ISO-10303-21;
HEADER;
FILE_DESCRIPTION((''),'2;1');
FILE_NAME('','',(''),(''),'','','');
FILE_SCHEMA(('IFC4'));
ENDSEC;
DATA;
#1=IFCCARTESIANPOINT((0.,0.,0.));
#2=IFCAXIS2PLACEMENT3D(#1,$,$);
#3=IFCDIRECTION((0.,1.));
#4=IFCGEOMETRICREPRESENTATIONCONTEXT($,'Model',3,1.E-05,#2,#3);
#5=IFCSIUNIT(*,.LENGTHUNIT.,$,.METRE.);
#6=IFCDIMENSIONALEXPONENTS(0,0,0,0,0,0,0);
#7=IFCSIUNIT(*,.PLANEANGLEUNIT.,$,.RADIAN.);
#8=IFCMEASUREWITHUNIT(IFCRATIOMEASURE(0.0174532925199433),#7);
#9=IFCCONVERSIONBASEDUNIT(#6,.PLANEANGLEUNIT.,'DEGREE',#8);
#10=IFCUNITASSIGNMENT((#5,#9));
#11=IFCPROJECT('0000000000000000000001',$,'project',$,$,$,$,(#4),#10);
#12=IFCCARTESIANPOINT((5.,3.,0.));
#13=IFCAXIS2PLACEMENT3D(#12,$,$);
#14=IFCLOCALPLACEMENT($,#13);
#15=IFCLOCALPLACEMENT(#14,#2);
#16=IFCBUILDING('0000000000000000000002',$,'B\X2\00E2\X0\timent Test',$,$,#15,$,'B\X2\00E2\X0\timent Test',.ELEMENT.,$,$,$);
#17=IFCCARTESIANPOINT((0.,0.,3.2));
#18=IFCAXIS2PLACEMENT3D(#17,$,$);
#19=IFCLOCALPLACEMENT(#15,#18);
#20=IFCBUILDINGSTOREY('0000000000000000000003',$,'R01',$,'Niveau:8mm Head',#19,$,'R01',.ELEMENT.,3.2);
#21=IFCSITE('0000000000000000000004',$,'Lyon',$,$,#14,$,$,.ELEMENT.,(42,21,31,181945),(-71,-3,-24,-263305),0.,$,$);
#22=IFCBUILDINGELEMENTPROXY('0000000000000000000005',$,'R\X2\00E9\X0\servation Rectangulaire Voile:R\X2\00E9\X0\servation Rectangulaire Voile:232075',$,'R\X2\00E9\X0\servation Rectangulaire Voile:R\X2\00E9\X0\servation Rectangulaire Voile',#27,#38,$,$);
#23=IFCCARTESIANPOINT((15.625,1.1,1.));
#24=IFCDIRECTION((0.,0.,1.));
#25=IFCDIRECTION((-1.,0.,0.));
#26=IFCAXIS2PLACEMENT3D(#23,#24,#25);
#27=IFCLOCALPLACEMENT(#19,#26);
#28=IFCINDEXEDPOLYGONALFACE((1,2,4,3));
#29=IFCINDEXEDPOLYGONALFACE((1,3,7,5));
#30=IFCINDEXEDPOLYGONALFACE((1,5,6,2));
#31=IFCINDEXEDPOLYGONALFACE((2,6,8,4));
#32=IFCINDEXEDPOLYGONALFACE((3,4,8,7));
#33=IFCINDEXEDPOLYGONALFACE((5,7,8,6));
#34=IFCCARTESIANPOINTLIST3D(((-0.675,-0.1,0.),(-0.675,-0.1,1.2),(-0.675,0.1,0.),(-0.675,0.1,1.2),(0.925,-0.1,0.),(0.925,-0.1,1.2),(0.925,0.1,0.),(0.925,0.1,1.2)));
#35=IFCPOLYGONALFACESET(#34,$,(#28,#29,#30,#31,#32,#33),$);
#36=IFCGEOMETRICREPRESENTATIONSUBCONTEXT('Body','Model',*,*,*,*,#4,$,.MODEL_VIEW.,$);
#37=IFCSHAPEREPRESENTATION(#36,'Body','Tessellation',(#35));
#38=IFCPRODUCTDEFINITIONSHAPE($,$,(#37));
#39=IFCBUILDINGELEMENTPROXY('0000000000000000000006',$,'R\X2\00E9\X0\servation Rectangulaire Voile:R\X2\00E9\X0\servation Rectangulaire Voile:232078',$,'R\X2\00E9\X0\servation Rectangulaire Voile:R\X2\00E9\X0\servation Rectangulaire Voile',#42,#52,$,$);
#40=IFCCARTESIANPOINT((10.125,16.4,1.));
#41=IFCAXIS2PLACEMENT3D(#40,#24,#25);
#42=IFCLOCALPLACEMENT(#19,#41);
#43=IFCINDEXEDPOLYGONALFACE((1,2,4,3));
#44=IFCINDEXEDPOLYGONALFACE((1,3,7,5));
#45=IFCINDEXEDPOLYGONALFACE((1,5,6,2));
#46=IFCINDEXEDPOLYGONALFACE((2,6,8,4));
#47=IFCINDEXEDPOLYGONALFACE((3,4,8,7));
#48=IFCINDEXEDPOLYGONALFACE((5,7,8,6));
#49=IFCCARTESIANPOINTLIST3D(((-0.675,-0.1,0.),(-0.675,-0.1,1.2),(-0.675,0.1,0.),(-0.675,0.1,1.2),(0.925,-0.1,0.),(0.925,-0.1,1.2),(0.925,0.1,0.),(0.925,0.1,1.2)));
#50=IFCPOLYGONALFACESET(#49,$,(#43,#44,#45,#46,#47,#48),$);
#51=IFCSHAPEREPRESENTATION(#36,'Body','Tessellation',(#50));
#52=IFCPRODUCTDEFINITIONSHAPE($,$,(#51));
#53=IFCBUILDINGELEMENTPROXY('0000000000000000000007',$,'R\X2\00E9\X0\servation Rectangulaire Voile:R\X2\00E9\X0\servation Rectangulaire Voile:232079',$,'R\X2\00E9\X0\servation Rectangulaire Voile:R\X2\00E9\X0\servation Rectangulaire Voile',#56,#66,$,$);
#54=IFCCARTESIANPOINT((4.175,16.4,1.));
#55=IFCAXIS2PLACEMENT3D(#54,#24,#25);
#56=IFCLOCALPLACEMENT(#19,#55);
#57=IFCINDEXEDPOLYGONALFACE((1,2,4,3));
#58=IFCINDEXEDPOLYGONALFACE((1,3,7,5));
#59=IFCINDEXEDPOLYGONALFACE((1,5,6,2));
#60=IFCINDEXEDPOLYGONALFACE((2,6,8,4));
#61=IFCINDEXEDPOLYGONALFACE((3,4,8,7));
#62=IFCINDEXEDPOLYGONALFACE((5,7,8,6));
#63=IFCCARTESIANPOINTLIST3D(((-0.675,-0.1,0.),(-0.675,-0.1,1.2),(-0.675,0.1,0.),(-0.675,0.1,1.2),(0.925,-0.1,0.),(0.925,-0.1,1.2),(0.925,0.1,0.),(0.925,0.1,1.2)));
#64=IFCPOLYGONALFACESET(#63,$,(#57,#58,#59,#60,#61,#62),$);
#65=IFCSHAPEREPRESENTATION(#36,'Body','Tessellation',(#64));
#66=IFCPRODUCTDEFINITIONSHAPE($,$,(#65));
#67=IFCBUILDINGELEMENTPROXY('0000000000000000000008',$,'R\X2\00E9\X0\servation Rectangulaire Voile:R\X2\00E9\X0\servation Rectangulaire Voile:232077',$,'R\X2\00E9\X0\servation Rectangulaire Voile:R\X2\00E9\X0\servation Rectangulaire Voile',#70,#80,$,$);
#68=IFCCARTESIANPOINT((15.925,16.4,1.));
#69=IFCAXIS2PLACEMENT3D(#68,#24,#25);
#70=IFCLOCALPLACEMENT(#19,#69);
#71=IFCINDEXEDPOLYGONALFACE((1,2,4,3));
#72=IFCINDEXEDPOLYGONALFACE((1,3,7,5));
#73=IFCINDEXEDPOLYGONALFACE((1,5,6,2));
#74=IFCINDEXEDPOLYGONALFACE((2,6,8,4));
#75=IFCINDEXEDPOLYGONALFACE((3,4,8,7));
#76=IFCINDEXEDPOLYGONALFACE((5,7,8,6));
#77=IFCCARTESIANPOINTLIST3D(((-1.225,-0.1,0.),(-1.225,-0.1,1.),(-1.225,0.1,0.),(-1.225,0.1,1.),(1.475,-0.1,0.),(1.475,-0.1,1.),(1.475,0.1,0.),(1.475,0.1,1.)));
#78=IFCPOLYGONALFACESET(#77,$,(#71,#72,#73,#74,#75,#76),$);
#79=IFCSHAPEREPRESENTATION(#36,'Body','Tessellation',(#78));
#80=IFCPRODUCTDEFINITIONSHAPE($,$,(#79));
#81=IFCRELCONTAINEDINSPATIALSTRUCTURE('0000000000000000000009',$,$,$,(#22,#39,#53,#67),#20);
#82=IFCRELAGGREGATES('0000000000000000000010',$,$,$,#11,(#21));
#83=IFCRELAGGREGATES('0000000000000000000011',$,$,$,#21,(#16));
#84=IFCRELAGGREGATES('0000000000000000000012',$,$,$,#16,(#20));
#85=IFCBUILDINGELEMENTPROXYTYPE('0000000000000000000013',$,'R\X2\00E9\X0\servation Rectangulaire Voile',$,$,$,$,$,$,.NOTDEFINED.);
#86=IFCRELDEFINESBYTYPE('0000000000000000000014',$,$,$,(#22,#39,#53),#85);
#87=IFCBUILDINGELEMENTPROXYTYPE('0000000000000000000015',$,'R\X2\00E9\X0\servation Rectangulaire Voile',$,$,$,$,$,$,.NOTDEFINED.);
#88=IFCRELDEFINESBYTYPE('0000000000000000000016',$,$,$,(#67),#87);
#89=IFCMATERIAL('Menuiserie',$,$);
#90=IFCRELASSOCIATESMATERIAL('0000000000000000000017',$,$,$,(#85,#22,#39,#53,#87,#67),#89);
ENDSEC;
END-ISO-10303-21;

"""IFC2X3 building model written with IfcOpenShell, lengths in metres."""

from ifc_helpers import new_model, entity, si_unit, converted_unit, direction, frame, origin, origin_2d_with_axis, place, context, subcontext, project, spatial, rectangle, extrude, source, transform, mapped, material, type_object, type_shapes, element, save


model = new_model("IFC2X3")

# Units and contexts
model_context = context("Model", 3, precision=1e-05, world=origin(), true_north=direction((0.0, 1.0)))
body_context = subcontext(model_context, "Body", "Model", "MODEL_VIEW")
ifc_project = project(units=[si_unit("LENGTHUNIT", "METRE"), converted_unit("PLANEANGLEUNIT", "DEGREE", entity("IfcRatioMeasure", 0.0174532925199433), si_unit("PLANEANGLEUNIT", "RADIAN"), dimensions=[0, 0, 0, 0, 0, 0, 0])], contexts=[model_context])

# Site, building, storey
site_placement = place(None, frame((5.0, 3.0, 0.0)))
site = spatial("IfcSite", under=ifc_project, at=site_placement, Name="Lyon", CompositionType="ELEMENT", RefLatitude=(42, 21, 31, 181945), RefLongitude=(-71, -3, -24, -263305), RefElevation=0.0)
building_placement = place(site_placement, origin())
building = spatial("IfcBuilding", under=site, at=building_placement, Name="Bâtiment Test", LongName="Bâtiment Test", CompositionType="ELEMENT")
storey_placement = place(building_placement, frame((0.0, 0.0, 3.2)))
storey = spatial("IfcBuildingStorey", under=building, at=storey_placement, Name="R01", ObjectType="Niveau:8mm Head", LongName="R01", CompositionType="ELEMENT", Elevation=3.2)

# Building element proxies
ifc_material_1 = material(Name="Menuiserie")
building_element_proxy_type_1 = type_object("IfcBuildingElementProxyType", Name="Réservation Rectangulaire Voile", PredefinedType="NOTDEFINED", material=ifc_material_1)
shared_shape_1 = source(origin(), body_context, "Body", "SweptSolid", [
    extrude(rectangle(XDim=0.2, YDim=1.6, at=origin_2d_with_axis()), frame((0.125, 0.0, 0.0), z_axis=(0.0, 0.0, 1.0), x_axis=(0.0, 1.0, 0.0)), (0.0, 0.0, 1.0), 1.2),
])
type_shapes(building_element_proxy_type_1, [shared_shape_1])
for number, where, z_axis, x_axis, name in (
    (1, (15.625, 1.1, 1.0), (0.0, 0.0, 1.0), (-1.0, 0.0, 0.0), "Réservation Rectangulaire Voile:Réservation Rectangulaire Voile:232075"),
    (2, (10.125, 16.4, 1.0), (0.0, 0.0, 1.0), (-1.0, 0.0, 0.0), "Réservation Rectangulaire Voile:Réservation Rectangulaire Voile:232078"),
    (3, (4.175, 16.4, 1.0), (0.0, 0.0, 1.0), (-1.0, 0.0, 0.0), "Réservation Rectangulaire Voile:Réservation Rectangulaire Voile:232079"),
):
    element("IfcBuildingElementProxy", number, at=place(storey_placement, frame(where, z_axis=z_axis, x_axis=x_axis)), inside=storey, type_object=building_element_proxy_type_1, material=ifc_material_1, Name=name, ObjectType="Réservation Rectangulaire Voile:Réservation Rectangulaire Voile", context=body_context, shape_type="MappedRepresentation", body=[
        mapped(shared_shape_1, transform((0.0, 0.0, 0.0), scale=1.0)),
    ])
building_element_proxy_type_2 = type_object("IfcBuildingElementProxyType", Name="Réservation Rectangulaire Voile", PredefinedType="NOTDEFINED", material=ifc_material_1)
shared_shape_2 = source(origin(), body_context, "Body", "SweptSolid", [
    extrude(rectangle(XDim=0.2, YDim=2.7, at=origin_2d_with_axis()), frame((0.125, 0.0, 0.0), z_axis=(0.0, 0.0, 1.0), x_axis=(0.0, 1.0, 0.0)), (0.0, 0.0, 1.0), 1.0),
])
type_shapes(building_element_proxy_type_2, [shared_shape_2])
proxy_1_placement = place(storey_placement, frame((15.925, 16.4, 1.0), z_axis=(0.0, 0.0, 1.0), x_axis=(-1.0, 0.0, 0.0)))
element("IfcBuildingElementProxy", 4, at=proxy_1_placement, inside=storey, type_object=building_element_proxy_type_2, material=ifc_material_1, Name="Réservation Rectangulaire Voile:Réservation Rectangulaire Voile:232077", ObjectType="Réservation Rectangulaire Voile:Réservation Rectangulaire Voile", context=body_context, shape_type="MappedRepresentation", body=[
    mapped(shared_shape_2, transform((0.0, 0.0, 0.0), scale=1.0)),
])

save(model, "model.ifc")
